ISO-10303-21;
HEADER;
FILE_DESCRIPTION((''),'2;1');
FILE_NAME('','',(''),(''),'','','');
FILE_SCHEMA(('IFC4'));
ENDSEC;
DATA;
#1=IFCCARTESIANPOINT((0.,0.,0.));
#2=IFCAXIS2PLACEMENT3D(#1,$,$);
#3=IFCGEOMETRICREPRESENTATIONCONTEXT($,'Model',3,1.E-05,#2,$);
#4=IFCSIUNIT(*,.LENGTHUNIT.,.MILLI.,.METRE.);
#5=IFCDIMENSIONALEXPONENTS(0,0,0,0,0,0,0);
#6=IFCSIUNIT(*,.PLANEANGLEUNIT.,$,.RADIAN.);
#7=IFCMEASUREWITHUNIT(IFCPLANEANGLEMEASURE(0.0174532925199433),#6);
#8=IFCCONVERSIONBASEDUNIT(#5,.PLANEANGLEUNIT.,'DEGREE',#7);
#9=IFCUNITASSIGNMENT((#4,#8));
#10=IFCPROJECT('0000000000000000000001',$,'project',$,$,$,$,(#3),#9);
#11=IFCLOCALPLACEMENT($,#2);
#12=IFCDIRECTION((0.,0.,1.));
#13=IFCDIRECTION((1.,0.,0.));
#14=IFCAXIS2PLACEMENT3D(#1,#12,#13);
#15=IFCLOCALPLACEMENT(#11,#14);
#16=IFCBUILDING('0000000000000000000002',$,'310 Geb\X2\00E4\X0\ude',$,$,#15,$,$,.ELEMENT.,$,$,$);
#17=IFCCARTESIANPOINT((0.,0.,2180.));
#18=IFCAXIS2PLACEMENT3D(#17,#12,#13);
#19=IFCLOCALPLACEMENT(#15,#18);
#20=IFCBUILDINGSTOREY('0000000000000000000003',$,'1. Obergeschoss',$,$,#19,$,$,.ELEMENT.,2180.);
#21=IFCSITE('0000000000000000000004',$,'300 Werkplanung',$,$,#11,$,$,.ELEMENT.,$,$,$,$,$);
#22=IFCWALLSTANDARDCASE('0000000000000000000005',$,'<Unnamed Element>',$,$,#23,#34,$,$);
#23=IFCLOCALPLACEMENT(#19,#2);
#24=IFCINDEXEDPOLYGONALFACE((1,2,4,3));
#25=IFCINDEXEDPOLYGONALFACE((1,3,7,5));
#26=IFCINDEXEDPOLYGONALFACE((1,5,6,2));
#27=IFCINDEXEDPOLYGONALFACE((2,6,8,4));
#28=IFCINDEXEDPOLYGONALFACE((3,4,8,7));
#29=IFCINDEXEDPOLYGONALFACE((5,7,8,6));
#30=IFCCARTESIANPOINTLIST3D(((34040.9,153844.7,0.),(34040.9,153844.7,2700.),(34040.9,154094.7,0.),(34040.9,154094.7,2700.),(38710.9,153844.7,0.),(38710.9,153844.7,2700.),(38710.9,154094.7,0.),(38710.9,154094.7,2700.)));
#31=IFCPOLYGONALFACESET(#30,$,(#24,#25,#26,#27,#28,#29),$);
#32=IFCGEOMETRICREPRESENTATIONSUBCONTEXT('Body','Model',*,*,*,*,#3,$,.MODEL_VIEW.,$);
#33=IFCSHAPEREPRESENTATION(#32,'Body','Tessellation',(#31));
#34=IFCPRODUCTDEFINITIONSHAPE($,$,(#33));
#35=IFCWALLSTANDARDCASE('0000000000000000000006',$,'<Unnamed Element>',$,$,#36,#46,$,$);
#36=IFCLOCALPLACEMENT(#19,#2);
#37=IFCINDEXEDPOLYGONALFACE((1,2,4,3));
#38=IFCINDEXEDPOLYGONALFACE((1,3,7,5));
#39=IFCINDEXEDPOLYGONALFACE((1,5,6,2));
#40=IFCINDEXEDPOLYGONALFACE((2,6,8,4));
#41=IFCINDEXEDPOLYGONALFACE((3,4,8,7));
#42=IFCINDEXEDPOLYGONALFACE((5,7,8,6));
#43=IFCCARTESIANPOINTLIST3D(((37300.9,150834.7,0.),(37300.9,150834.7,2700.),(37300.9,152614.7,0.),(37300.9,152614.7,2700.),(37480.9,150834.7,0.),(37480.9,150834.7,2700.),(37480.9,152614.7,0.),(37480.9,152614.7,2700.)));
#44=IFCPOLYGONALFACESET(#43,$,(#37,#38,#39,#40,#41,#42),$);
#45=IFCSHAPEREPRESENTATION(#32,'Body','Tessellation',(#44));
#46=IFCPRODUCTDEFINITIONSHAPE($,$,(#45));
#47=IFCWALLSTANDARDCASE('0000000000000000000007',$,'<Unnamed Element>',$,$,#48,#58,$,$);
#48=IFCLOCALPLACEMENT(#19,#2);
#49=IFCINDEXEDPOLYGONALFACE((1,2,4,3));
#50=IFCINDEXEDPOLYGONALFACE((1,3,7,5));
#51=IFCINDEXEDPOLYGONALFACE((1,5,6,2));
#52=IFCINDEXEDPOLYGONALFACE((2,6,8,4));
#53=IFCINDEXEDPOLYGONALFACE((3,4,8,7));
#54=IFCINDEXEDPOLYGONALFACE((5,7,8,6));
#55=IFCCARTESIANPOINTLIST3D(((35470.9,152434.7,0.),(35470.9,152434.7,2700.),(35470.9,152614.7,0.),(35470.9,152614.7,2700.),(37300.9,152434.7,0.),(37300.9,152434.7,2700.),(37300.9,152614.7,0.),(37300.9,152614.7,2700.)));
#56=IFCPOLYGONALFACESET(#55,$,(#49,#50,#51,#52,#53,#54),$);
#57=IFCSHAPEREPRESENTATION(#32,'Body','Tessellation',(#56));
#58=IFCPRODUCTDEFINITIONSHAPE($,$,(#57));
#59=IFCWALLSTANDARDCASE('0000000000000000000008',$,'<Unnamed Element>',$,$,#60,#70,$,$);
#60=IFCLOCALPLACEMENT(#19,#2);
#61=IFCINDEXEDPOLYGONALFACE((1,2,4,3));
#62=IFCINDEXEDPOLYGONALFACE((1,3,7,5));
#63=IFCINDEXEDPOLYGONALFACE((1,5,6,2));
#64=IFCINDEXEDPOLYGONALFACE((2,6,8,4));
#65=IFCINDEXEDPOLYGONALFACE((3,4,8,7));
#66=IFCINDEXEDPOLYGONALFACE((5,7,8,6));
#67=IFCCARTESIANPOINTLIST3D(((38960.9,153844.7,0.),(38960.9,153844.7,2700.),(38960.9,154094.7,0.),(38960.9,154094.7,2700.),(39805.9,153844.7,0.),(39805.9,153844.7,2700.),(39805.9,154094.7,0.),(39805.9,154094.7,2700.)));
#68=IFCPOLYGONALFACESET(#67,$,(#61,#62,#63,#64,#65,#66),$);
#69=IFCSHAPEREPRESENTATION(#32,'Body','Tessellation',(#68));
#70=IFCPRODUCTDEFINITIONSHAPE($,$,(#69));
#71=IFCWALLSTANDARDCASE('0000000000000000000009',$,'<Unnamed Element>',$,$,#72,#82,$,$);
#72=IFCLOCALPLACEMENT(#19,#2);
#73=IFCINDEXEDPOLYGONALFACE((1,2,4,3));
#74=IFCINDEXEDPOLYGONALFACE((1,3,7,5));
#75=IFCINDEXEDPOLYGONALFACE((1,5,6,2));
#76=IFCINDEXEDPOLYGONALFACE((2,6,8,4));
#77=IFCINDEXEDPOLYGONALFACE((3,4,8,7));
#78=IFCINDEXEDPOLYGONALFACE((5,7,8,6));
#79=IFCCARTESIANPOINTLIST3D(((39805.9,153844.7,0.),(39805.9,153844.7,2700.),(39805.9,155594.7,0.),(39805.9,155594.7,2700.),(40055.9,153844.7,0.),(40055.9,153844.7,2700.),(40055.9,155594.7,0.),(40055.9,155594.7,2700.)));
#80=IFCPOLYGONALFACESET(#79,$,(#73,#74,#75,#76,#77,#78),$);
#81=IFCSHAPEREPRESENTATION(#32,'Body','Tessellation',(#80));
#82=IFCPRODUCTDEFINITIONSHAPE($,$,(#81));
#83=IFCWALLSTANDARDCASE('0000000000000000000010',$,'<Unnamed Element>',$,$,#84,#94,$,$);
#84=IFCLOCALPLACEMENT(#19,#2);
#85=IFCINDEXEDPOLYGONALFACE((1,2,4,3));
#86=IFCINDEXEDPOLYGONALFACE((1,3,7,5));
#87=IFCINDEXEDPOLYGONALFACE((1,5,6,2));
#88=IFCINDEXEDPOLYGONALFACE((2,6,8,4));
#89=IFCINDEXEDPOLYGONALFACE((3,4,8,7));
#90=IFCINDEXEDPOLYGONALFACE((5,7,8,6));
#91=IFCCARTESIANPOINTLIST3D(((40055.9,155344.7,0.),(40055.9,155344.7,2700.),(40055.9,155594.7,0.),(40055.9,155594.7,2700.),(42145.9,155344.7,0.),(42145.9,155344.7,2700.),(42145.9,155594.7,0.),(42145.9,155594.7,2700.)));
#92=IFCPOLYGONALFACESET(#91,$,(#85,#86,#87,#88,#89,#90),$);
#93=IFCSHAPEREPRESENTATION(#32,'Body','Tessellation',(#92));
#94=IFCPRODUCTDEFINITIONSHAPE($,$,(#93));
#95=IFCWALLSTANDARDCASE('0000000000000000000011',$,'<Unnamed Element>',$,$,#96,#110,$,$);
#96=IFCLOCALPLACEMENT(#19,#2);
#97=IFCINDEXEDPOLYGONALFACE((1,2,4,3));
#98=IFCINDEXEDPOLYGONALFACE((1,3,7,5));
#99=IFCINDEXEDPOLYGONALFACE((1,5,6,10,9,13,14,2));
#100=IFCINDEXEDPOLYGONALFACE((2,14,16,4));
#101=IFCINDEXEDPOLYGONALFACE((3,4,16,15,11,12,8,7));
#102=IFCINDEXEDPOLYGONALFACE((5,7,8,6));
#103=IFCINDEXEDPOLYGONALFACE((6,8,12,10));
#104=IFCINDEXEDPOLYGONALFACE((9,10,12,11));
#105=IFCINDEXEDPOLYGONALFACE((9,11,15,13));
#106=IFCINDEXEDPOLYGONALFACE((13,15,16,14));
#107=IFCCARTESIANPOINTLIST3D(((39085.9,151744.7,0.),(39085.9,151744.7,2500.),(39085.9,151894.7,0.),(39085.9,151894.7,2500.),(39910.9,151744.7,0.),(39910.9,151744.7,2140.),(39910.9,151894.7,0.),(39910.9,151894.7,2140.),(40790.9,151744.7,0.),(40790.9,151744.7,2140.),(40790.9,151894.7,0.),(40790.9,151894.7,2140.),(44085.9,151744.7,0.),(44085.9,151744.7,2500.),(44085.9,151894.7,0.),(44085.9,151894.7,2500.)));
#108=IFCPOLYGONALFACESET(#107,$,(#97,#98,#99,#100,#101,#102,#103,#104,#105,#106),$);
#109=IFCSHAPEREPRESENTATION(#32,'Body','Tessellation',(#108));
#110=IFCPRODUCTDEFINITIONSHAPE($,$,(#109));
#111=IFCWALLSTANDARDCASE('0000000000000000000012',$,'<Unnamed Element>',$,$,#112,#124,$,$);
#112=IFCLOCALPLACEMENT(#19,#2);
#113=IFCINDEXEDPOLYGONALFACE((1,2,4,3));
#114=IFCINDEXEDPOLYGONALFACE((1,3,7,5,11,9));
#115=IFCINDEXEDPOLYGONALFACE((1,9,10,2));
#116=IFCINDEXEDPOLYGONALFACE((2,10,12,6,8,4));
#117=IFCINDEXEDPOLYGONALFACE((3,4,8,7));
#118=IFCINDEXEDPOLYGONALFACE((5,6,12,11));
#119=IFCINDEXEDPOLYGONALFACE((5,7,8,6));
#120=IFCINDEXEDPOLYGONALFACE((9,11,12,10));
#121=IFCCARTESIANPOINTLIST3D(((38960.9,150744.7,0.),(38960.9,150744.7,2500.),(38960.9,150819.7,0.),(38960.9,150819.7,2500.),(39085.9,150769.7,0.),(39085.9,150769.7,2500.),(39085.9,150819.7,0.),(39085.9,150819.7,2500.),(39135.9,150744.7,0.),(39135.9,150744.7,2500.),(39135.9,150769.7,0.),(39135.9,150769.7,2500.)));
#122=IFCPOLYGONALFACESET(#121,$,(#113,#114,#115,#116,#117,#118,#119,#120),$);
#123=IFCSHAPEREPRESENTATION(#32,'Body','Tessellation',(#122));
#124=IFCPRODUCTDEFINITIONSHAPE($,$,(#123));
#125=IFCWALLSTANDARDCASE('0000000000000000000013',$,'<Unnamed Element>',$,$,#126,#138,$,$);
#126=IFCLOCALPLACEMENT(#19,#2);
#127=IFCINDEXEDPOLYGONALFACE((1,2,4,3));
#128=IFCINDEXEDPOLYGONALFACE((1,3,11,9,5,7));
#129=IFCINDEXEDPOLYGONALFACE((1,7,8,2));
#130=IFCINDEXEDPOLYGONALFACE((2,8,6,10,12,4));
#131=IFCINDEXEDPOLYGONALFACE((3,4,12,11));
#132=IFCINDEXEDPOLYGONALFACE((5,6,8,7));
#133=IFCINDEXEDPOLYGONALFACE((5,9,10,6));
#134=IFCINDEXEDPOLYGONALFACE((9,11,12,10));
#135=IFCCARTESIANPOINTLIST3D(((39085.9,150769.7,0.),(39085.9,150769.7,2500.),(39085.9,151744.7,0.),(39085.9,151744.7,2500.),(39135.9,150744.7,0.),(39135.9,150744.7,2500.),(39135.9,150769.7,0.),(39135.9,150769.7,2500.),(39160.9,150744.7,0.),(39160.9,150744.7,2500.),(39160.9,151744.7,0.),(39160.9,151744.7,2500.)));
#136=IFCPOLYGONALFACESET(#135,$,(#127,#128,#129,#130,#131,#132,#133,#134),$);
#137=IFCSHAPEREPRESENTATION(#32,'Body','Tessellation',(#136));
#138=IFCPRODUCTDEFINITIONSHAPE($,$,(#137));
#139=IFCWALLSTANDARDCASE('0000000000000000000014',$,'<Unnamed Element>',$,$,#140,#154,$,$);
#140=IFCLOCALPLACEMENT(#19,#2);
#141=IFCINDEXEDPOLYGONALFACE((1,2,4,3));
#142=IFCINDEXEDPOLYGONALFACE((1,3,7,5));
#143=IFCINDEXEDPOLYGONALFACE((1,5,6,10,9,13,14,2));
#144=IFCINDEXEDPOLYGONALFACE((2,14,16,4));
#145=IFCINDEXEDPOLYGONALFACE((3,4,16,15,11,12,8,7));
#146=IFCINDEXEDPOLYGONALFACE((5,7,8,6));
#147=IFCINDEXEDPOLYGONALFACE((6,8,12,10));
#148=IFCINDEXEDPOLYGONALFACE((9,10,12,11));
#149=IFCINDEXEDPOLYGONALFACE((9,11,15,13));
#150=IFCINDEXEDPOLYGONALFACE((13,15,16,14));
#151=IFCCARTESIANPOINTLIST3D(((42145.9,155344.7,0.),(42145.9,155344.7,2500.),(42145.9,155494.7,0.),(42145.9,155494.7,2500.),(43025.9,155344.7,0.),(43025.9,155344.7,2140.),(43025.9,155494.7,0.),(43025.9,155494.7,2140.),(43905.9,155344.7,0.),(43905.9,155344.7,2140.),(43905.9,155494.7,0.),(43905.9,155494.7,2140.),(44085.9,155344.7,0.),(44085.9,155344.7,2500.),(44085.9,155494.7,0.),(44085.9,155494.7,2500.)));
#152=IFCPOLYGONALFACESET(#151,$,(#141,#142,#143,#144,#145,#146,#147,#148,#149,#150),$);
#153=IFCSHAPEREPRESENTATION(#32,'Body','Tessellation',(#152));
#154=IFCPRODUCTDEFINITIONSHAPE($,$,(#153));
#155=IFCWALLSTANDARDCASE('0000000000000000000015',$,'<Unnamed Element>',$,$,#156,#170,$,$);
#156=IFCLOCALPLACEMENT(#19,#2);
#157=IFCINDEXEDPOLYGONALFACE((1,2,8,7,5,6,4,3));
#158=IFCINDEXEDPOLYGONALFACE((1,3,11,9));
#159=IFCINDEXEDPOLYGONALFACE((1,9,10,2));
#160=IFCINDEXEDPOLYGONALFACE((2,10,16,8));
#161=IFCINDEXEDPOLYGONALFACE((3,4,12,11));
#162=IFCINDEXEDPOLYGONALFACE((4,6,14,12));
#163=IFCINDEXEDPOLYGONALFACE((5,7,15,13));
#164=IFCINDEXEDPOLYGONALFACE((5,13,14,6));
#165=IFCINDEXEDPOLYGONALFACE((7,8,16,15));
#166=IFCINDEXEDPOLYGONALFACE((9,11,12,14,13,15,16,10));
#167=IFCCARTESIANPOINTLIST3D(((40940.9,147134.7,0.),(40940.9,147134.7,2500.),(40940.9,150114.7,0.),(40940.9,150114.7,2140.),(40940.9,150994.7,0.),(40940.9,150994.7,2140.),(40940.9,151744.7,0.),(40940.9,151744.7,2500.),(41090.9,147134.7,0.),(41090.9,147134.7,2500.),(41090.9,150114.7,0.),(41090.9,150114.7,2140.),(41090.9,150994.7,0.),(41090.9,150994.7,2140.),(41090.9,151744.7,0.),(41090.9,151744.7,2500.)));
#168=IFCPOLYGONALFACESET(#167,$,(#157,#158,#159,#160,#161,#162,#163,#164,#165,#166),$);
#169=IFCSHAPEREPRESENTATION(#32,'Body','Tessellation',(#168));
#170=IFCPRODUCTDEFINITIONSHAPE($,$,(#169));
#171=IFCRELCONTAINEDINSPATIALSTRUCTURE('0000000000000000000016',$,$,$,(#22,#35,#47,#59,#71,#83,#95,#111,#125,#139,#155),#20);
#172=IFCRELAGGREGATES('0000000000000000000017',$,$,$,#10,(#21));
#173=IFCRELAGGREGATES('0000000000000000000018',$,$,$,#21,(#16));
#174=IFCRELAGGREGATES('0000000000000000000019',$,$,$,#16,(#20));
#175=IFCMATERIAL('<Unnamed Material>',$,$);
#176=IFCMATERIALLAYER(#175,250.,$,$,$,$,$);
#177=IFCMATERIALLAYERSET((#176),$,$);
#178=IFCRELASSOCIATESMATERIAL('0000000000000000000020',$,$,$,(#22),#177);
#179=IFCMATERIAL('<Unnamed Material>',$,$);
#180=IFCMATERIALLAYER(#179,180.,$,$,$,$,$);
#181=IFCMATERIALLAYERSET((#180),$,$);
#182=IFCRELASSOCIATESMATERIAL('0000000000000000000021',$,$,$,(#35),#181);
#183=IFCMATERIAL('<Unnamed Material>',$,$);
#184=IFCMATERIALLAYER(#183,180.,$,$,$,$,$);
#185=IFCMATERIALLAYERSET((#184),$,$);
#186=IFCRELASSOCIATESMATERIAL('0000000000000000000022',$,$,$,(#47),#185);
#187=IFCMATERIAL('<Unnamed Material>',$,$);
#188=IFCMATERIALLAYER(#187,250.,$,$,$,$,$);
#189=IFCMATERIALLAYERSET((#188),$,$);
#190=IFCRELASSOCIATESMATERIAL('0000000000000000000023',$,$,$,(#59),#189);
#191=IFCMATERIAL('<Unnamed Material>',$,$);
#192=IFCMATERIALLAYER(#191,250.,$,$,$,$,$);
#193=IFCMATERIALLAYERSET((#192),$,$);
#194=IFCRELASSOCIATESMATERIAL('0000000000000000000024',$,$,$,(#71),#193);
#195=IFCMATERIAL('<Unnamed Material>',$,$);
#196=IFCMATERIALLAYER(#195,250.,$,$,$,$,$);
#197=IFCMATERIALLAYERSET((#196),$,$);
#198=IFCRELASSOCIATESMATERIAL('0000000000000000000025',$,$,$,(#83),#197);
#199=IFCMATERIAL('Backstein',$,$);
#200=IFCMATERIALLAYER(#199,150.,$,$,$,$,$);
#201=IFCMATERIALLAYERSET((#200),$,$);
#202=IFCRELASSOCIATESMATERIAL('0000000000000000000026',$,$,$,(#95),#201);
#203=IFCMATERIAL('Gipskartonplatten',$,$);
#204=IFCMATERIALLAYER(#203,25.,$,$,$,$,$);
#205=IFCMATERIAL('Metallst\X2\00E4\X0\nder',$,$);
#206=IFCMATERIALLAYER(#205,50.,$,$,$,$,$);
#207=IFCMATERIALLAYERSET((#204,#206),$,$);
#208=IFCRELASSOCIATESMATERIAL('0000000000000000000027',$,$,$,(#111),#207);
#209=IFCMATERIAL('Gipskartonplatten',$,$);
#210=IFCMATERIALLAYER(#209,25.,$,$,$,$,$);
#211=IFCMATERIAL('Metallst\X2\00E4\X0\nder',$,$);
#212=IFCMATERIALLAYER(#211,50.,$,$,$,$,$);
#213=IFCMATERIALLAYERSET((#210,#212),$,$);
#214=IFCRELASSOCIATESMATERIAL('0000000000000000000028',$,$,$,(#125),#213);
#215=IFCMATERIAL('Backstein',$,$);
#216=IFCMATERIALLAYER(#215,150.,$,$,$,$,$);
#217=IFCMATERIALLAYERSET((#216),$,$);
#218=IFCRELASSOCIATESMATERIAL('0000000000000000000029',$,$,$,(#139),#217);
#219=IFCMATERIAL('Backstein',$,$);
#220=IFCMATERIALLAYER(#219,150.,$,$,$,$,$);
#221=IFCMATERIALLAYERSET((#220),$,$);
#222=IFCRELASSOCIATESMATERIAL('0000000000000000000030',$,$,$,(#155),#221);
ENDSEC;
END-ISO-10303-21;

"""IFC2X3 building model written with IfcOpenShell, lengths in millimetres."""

from ifc_helpers import new_model, entity, si_unit, converted_unit, frame, frame_2d, origin, origin_with_axes, place, context, subcontext, project, spatial, polyline, rectangle, outline, extrude, material, layer, layer_set, layer_usage, element, save


model = new_model("IFC2X3")

# Units and contexts
model_context = context("Model", 3, precision=1e-05, world=origin())
body_context = subcontext(model_context, "Body", "Model", "MODEL_VIEW")
ifc_project = project(units=[si_unit("LENGTHUNIT", "METRE", prefix="MILLI"), converted_unit("PLANEANGLEUNIT", "DEGREE", entity("IfcPlaneAngleMeasure", 0.0174532925199433), si_unit("PLANEANGLEUNIT", "RADIAN"), dimensions=[0, 0, 0, 0, 0, 0, 0])], contexts=[model_context])

# Site, building, storey
site_placement = place(None, origin())
site = spatial("IfcSite", under=ifc_project, at=site_placement, Name="300 Werkplanung", CompositionType="ELEMENT")
building_placement = place(site_placement, origin_with_axes())
building = spatial("IfcBuilding", under=site, at=building_placement, Name="310 Gebäude", CompositionType="ELEMENT")
storey_placement = place(building_placement, frame((0.0, 0.0, 2180.0), z_axis=(0.0, 0.0, 1.0), x_axis=(1.0, 0.0, 0.0)))
storey = spatial("IfcBuildingStorey", under=building, at=storey_placement, Name="1. Obergeschoss", CompositionType="ELEMENT", Elevation=2180.0)

# Walls
ifc_material_1 = material(Name="<Unnamed Material>")
ifc_layer_1 = layer(ifc_material_1, 250.0)
ifc_layer_set_1 = layer_set([ifc_layer_1])
ifc_layer_usage_1 = layer_usage(ifc_layer_set_1, "AXIS2", "POSITIVE", -250.0)
wall_1_placement = place(storey_placement, frame((38710.9, 154094.7, 0.0), z_axis=(0.0, 0.0, 1.0), x_axis=(-1.0, 0.0, 0.0)))
element("IfcWallStandardCase", 1, at=wall_1_placement, inside=storey, material=ifc_layer_usage_1, Name="<Unnamed Element>", context=body_context, shape_type="SweptSolid", body=[
    extrude(rectangle(XDim=4670.0, YDim=250.0, at=frame_2d((2335.0, 125.0), x_axis=(1.0, 0.0))), origin_with_axes(), (0.0, 0.0, 1.0), 2700.0),
])
ifc_material_2 = material(Name="<Unnamed Material>")
ifc_layer_2 = layer(ifc_material_2, 180.0)
ifc_layer_set_2 = layer_set([ifc_layer_2])
ifc_layer_usage_2 = layer_usage(ifc_layer_set_2, "AXIS2", "POSITIVE", -180.0)
wall_2_placement = place(storey_placement, frame((37480.9, 150834.7, 0.0), z_axis=(0.0, 0.0, 1.0), x_axis=(0.0, 1.0, 0.0)))
element("IfcWallStandardCase", 2, at=wall_2_placement, inside=storey, material=ifc_layer_usage_2, Name="<Unnamed Element>", context=body_context, shape_type="SweptSolid", body=[
    extrude(rectangle(XDim=1780.0, YDim=180.0, at=frame_2d((890.0, 90.0), x_axis=(1.0, 0.0))), origin_with_axes(), (0.0, 0.0, 1.0), 2700.0),
])
ifc_material_3 = material(Name="<Unnamed Material>")
ifc_layer_3 = layer(ifc_material_3, 180.0)
ifc_layer_set_3 = layer_set([ifc_layer_3])
ifc_layer_usage_3 = layer_usage(ifc_layer_set_3, "AXIS2", "POSITIVE", -180.0)
wall_3_placement = place(storey_placement, frame((37300.9, 152614.7, 0.0), z_axis=(0.0, 0.0, 1.0), x_axis=(-1.0, 0.0, 0.0)))
element("IfcWallStandardCase", 3, at=wall_3_placement, inside=storey, material=ifc_layer_usage_3, Name="<Unnamed Element>", context=body_context, shape_type="SweptSolid", body=[
    extrude(rectangle(XDim=1830.0, YDim=180.0, at=frame_2d((915.0, 90.0), x_axis=(1.0, 0.0))), origin_with_axes(), (0.0, 0.0, 1.0), 2700.0),
])
ifc_material_4 = material(Name="<Unnamed Material>")
ifc_layer_4 = layer(ifc_material_4, 250.0)
ifc_layer_set_4 = layer_set([ifc_layer_4])
ifc_layer_usage_4 = layer_usage(ifc_layer_set_4, "AXIS2", "POSITIVE", -250.0)
wall_4_placement = place(storey_placement, frame((38960.9, 153844.7, 0.0), z_axis=(0.0, 0.0, 1.0), x_axis=(1.0, 0.0, 0.0)))
element("IfcWallStandardCase", 4, at=wall_4_placement, inside=storey, material=ifc_layer_usage_4, Name="<Unnamed Element>", context=body_context, shape_type="SweptSolid", body=[
    extrude(rectangle(XDim=845.0, YDim=250.0, at=frame_2d((422.5, 125.0), x_axis=(1.0, 0.0))), origin_with_axes(), (0.0, 0.0, 1.0), 2700.0),
])
ifc_material_5 = material(Name="<Unnamed Material>")
ifc_layer_5 = layer(ifc_material_5, 250.0)
ifc_layer_set_5 = layer_set([ifc_layer_5])
ifc_layer_usage_5 = layer_usage(ifc_layer_set_5, "AXIS2", "POSITIVE", -250.0)
wall_5_placement = place(storey_placement, frame((40055.9, 153844.7, 0.0), z_axis=(0.0, 0.0, 1.0), x_axis=(0.0, 1.0, 0.0)))
element("IfcWallStandardCase", 5, at=wall_5_placement, inside=storey, material=ifc_layer_usage_5, Name="<Unnamed Element>", context=body_context, shape_type="SweptSolid", body=[
    extrude(rectangle(XDim=1750.0, YDim=250.0, at=frame_2d((875.0, 125.0), x_axis=(1.0, 0.0))), origin_with_axes(), (0.0, 0.0, 1.0), 2700.0),
])
ifc_material_6 = material(Name="<Unnamed Material>")
ifc_layer_6 = layer(ifc_material_6, 250.0)
ifc_layer_set_6 = layer_set([ifc_layer_6])
ifc_layer_usage_6 = layer_usage(ifc_layer_set_6, "AXIS2", "POSITIVE", -250.0)
wall_6_placement = place(storey_placement, frame((40055.9, 155344.7, 0.0), z_axis=(0.0, 0.0, 1.0), x_axis=(1.0, 0.0, 0.0)))
element("IfcWallStandardCase", 6, at=wall_6_placement, inside=storey, material=ifc_layer_usage_6, Name="<Unnamed Element>", context=body_context, shape_type="SweptSolid", body=[
    extrude(rectangle(XDim=2090.0, YDim=250.0, at=frame_2d((1045.0, 125.0), x_axis=(1.0, 0.0))), origin_with_axes(), (0.0, 0.0, 1.0), 2700.0),
])

# Wall, opening
ifc_material_7 = material(Name="Backstein")
ifc_layer_7 = layer(ifc_material_7, 150.0)
ifc_layer_set_7 = layer_set([ifc_layer_7])
ifc_layer_usage_7 = layer_usage(ifc_layer_set_7, "AXIS2", "POSITIVE", 0.0)
wall_7_placement = place(storey_placement, frame((44085.9, 151894.7, 0.0), z_axis=(0.0, 0.0, 1.0), x_axis=(-1.0, 0.0, 0.0)))
wall_7 = element("IfcWallStandardCase", 7, at=wall_7_placement, inside=storey, material=ifc_layer_usage_7, Name="<Unnamed Element>", context=body_context, shape_type="SweptSolid", body=[
    extrude(rectangle(XDim=5000.0, YDim=150.0, at=frame_2d((2500.0, 75.0), x_axis=(1.0, 0.0))), origin_with_axes(), (0.0, 0.0, 1.0), 2500.0),
])
opening_1_placement = place(wall_7_placement, frame((3295.0, 0.0, 0.0), z_axis=(0.0, 1.0, 0.0), x_axis=(0.0, 0.0, 1.0)))
element("IfcOpeningElement", 8, at=opening_1_placement, cuts=wall_7, ObjectType="Opening", context=body_context, shape_type="SweptSolid", body=[
    extrude(rectangle(XDim=2140.0, YDim=880.0, at=frame_2d((1070.0, 440.0), x_axis=(1.0, 0.0))), origin_with_axes(), (0.0, 0.0, 1.0), 150.0),
])

# Walls
ifc_material_8 = material(Name="Gipskartonplatten")
ifc_layer_8 = layer(ifc_material_8, 25.0)
ifc_material_9 = material(Name="Metallständer")
ifc_layer_9 = layer(ifc_material_9, 50.0)
ifc_layer_set_8 = layer_set([ifc_layer_8, ifc_layer_9])
ifc_layer_usage_8 = layer_usage(ifc_layer_set_8, "AXIS2", "POSITIVE", 0.0)
wall_8_placement = place(storey_placement, frame((38960.9, 150744.7, 0.0), z_axis=(0.0, 0.0, 1.0), x_axis=(1.0, 0.0, 0.0)))
element("IfcWallStandardCase", 9, at=wall_8_placement, inside=storey, material=ifc_layer_usage_8, Name="<Unnamed Element>", context=body_context, shape_type="SweptSolid", body=[
    extrude(outline(polyline([(0.0, 0.0), (175.0, 0.0), (175.0, 25.0), (125.0, 25.0), (125.0, 75.0), (0.0, 75.0), (0.0, 0.0)])), origin_with_axes(), (0.0, 0.0, 1.0), 2500.0),
])
ifc_material_10 = material(Name="Gipskartonplatten")
ifc_layer_10 = layer(ifc_material_10, 25.0)
ifc_material_11 = material(Name="Metallständer")
ifc_layer_11 = layer(ifc_material_11, 50.0)
ifc_layer_set_9 = layer_set([ifc_layer_10, ifc_layer_11])
ifc_layer_usage_9 = layer_usage(ifc_layer_set_9, "AXIS2", "POSITIVE", 0.0)
wall_9_placement = place(storey_placement, frame((39160.9, 150744.7, 0.0), z_axis=(0.0, 0.0, 1.0), x_axis=(0.0, 1.0, 0.0)))
element("IfcWallStandardCase", 10, at=wall_9_placement, inside=storey, material=ifc_layer_usage_9, Name="<Unnamed Element>", context=body_context, shape_type="SweptSolid", body=[
    extrude(outline(polyline([(25.0, 75.0), (25.0, 25.0), (0.0, 25.0), (0.0, 0.0), (1000.0, 0.0), (1000.0, 75.0), (25.0, 75.0)])), origin_with_axes(), (0.0, 0.0, 1.0), 2500.0),
])

# Walls, openings
ifc_material_12 = material(Name="Backstein")
ifc_layer_12 = layer(ifc_material_12, 150.0)
ifc_layer_set_10 = layer_set([ifc_layer_12])
ifc_layer_usage_10 = layer_usage(ifc_layer_set_10, "AXIS2", "POSITIVE", 0.0)
wall_10_placement = place(storey_placement, frame((42145.9, 155344.7, 0.0), z_axis=(0.0, 0.0, 1.0), x_axis=(1.0, 0.0, 0.0)))
wall_10 = element("IfcWallStandardCase", 11, at=wall_10_placement, inside=storey, material=ifc_layer_usage_10, Name="<Unnamed Element>", context=body_context, shape_type="SweptSolid", body=[
    extrude(rectangle(XDim=1940.0, YDim=150.0, at=frame_2d((970.0, 75.0), x_axis=(1.0, 0.0))), origin_with_axes(), (0.0, 0.0, 1.0), 2500.0),
])
opening_2_placement = place(wall_10_placement, frame((880.0, 0.0, 0.0), z_axis=(0.0, 1.0, 0.0), x_axis=(0.0, 0.0, 1.0)))
element("IfcOpeningElement", 12, at=opening_2_placement, cuts=wall_10, ObjectType="Opening", context=body_context, shape_type="SweptSolid", body=[
    extrude(rectangle(XDim=2140.0, YDim=880.0, at=frame_2d((1070.0, 440.0), x_axis=(1.0, 0.0))), origin_with_axes(), (0.0, 0.0, 1.0), 150.0),
])
ifc_material_13 = material(Name="Backstein")
ifc_layer_13 = layer(ifc_material_13, 150.0)
ifc_layer_set_11 = layer_set([ifc_layer_13])
ifc_layer_usage_11 = layer_usage(ifc_layer_set_11, "AXIS2", "POSITIVE", 0.0)
wall_11_placement = place(storey_placement, frame((40940.9, 151744.7, 0.0), z_axis=(0.0, 0.0, 1.0), x_axis=(0.0, -1.0, 0.0)))
wall_11 = element("IfcWallStandardCase", 13, at=wall_11_placement, inside=storey, material=ifc_layer_usage_11, Name="<Unnamed Element>", context=body_context, shape_type="SweptSolid", body=[
    extrude(rectangle(XDim=4610.0, YDim=150.0, at=frame_2d((2305.0, 75.0), x_axis=(1.0, 0.0))), origin_with_axes(), (0.0, 0.0, 1.0), 2500.0),
])
opening_3_placement = place(wall_11_placement, frame((750.0, 0.0, 0.0), z_axis=(0.0, 1.0, 0.0), x_axis=(0.0, 0.0, 1.0)))
element("IfcOpeningElement", 14, at=opening_3_placement, cuts=wall_11, ObjectType="Opening", context=body_context, shape_type="SweptSolid", body=[
    extrude(rectangle(XDim=2140.0, YDim=880.0, at=frame_2d((1070.0, 440.0), x_axis=(1.0, 0.0))), origin_with_axes(), (0.0, 0.0, 1.0), 150.0),
])

save(model, "model.ifc")
